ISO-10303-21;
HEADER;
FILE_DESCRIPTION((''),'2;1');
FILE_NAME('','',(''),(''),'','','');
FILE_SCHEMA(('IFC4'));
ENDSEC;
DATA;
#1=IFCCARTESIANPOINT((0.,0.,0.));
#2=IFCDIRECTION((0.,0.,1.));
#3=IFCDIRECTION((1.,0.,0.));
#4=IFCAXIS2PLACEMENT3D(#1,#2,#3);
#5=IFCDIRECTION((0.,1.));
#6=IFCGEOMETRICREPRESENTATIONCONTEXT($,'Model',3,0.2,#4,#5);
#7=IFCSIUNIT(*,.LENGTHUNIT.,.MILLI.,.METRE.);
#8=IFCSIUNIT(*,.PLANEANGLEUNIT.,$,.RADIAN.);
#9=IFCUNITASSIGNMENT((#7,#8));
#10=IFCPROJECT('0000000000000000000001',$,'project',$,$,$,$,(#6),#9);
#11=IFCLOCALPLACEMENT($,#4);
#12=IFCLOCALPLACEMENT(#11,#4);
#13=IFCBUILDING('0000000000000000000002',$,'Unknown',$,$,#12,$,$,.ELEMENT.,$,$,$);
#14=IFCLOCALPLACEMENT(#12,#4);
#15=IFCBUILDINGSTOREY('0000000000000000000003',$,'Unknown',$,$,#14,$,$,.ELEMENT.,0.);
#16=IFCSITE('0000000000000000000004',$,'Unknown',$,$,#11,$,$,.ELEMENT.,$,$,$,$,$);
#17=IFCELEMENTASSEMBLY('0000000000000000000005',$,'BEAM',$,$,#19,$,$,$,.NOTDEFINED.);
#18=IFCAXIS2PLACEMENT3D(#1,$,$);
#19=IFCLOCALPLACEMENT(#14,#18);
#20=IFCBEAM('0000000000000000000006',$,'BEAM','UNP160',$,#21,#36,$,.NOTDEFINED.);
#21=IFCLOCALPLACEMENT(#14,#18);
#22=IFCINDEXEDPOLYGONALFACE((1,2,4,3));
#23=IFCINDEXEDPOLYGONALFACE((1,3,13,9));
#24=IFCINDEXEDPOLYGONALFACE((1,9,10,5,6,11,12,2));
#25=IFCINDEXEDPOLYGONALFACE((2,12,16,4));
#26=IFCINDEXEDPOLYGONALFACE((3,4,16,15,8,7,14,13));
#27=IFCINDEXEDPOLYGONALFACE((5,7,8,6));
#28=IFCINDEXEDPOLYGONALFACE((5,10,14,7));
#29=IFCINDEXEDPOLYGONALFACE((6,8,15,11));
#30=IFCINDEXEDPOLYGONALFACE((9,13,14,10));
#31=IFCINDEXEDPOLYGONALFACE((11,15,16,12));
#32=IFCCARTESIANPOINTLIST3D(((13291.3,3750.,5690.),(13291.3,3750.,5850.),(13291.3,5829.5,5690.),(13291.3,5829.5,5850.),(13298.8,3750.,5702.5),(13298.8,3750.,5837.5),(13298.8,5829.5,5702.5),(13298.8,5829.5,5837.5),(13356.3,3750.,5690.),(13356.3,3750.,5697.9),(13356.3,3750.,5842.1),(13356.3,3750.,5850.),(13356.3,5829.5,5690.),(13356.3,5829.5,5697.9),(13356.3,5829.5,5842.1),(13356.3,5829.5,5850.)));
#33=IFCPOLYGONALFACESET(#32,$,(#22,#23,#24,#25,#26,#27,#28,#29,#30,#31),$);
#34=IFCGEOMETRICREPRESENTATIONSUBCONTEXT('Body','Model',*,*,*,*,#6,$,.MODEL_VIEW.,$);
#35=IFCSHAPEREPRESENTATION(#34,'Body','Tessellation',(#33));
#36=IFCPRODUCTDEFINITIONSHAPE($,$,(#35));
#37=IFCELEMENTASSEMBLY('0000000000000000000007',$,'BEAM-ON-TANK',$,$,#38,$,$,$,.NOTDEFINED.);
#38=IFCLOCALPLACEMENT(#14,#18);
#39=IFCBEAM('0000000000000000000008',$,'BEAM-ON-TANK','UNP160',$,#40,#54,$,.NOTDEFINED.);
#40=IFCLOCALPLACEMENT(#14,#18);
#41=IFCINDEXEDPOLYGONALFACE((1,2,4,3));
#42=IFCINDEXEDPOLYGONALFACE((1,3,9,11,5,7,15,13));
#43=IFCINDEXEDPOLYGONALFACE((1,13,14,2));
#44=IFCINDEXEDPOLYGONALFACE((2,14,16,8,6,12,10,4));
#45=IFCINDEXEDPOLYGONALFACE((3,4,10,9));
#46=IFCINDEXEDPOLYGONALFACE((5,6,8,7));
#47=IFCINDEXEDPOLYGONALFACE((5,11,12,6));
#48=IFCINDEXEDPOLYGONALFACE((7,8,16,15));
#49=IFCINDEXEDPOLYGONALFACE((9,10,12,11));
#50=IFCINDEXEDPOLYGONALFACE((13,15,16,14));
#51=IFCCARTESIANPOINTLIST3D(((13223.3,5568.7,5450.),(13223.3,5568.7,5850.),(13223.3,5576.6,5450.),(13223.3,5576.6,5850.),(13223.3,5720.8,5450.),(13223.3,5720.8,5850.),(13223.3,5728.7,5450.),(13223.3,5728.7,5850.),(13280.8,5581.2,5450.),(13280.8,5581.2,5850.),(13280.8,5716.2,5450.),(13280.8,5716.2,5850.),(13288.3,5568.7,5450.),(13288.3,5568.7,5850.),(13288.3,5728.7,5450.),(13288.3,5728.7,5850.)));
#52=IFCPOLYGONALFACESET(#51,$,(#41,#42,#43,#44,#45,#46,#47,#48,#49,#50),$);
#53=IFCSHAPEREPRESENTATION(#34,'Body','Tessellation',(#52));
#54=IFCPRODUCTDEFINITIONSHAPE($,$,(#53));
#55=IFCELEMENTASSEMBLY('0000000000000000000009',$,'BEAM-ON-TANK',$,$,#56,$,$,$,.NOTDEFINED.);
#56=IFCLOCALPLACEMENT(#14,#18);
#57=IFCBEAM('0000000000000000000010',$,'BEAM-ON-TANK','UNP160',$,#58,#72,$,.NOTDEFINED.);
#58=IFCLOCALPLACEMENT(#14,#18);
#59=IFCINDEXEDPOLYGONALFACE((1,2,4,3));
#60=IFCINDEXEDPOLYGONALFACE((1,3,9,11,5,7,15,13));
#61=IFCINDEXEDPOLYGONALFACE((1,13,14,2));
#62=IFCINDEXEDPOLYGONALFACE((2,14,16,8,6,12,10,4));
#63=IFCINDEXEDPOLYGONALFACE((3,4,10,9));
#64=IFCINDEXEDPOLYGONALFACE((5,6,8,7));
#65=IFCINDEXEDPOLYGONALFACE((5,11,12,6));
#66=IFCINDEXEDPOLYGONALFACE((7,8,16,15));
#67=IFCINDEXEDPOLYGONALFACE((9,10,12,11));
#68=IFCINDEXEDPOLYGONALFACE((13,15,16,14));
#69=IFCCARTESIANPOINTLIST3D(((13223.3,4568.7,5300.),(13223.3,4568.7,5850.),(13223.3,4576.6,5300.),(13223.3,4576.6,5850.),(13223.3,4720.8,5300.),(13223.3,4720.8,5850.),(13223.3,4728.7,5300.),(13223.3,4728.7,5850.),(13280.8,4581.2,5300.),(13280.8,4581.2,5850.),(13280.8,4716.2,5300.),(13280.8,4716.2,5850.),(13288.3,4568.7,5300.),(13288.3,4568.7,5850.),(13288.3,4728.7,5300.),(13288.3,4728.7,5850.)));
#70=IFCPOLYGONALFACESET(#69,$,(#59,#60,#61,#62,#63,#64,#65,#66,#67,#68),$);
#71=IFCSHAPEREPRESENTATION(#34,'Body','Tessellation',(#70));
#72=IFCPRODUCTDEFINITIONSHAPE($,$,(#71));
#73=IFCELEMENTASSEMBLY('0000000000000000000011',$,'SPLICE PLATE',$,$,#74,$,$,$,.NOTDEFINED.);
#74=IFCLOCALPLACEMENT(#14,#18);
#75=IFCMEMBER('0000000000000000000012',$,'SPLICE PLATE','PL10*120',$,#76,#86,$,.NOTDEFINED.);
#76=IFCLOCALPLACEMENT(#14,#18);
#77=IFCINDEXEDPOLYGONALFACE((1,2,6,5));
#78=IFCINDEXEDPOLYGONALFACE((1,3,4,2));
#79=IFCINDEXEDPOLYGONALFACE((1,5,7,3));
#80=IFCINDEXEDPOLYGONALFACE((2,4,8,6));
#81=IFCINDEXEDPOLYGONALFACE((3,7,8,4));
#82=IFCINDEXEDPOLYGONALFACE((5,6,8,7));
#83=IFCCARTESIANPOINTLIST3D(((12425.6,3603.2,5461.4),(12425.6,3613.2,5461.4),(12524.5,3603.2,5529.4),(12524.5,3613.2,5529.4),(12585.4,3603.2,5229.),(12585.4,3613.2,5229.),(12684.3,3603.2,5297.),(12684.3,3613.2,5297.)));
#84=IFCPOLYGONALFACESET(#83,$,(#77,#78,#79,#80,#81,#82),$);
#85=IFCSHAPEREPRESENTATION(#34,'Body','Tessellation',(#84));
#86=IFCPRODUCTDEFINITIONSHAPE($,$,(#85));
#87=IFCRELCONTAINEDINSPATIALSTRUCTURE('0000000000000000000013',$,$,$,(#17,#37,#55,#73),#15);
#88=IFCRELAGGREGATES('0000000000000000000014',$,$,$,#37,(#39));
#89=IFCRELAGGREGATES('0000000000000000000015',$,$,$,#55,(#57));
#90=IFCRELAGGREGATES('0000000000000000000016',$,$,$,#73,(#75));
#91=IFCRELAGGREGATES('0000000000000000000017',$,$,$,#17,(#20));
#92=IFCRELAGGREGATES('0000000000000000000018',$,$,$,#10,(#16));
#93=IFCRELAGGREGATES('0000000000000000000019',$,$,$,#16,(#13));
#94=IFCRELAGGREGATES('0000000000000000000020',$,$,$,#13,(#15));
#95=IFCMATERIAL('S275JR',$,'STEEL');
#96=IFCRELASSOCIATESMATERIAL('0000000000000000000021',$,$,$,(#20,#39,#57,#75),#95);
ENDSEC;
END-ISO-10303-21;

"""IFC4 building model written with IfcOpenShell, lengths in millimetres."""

from ifc_helpers import new_model, si_unit, direction, frame, origin_with_axes, place, context, subcontext, project, spatial, line, indexed_curve, outline, extrude, material, element, aggregate, save


model = new_model("IFC4")

# Units and contexts
model_context = context("Model", 3, precision=0.2, world=origin_with_axes(), true_north=direction((0.0, 1.0)))
body_context = subcontext(model_context, "Body", "Model", "MODEL_VIEW")
ifc_project = project(units=[si_unit("LENGTHUNIT", "METRE", prefix="MILLI"), si_unit("PLANEANGLEUNIT", "RADIAN")], contexts=[model_context])

# Site, building, storey
site_placement = place(None, origin_with_axes())
site = spatial("IfcSite", under=ifc_project, at=site_placement, Name="Unknown", CompositionType="ELEMENT")
building_placement = place(site_placement, origin_with_axes())
building = spatial("IfcBuilding", under=site, at=building_placement, Name="Unknown", CompositionType="ELEMENT")
storey_placement = place(building_placement, origin_with_axes())
storey = spatial("IfcBuildingStorey", under=building, at=storey_placement, Name="Unknown", CompositionType="ELEMENT", Elevation=0.0)

# Shared definitions
ifc_material_1 = material(Name="S275JR", Category="STEEL")

# Element assemblies, beams
assembly_1_placement = place(storey_placement, frame((13356.3, 5797.0, 5770.0), z_axis=(0.0, 1.0, 0.0), x_axis=(-1.0, 0.0, 0.0)))
assembly_1 = element("IfcElementAssembly", 1, at=assembly_1_placement, inside=storey, Name="BEAM", PredefinedType="NOTDEFINED")
beam_1_placement = place(assembly_1_placement, frame((32.5, 0.0, 32.5), z_axis=(-1.0, 0.0, 0.0), x_axis=(0.0, -0.000002, -1.0)))
beam_1 = element("IfcBeam", 2, at=beam_1_placement, material=ifc_material_1, Name="BEAM", Description="UNP160", PredefinedType="NOTDEFINED", context=body_context, shape_type="SolidModel", body=[
    extrude(outline(indexed_curve([(-32.5, -80.0), (32.5, -80.0), (32.5, -72.1), (-25.0, -67.5), (-25.0, 67.5), (32.5, 72.1), (32.5, 80.0), (-32.5, 80.0)], segments=[line(1, 2, 3, 4, 5, 6, 7, 8, 1)])), frame((0.0, 0.0, 0.0), z_axis=(-1.0, 0.0, 0.0), x_axis=(0.0, 0.0, 1.0)), (0.0, -0.000002, -1.0), 2079.5),
])
assembly_2_placement = place(storey_placement, frame((13255.8, 5648.7, 5850.0), z_axis=(-1.0, 0.0, 0.0), x_axis=(0.0, -0.000002, -1.0)))
assembly_2 = element("IfcElementAssembly", 3, at=assembly_2_placement, inside=storey, Name="BEAM-ON-TANK", PredefinedType="NOTDEFINED")
beam_2_placement = place(assembly_2_placement, origin_with_axes())
beam_2 = element("IfcBeam", 4, at=beam_2_placement, material=ifc_material_1, Name="BEAM-ON-TANK", Description="UNP160", PredefinedType="NOTDEFINED", context=body_context, shape_type="SolidModel", body=[
    extrude(outline(indexed_curve([(-32.5, -80.0), (32.5, -80.0), (32.5, -72.1), (-25.0, -67.5), (-25.0, 67.5), (32.5, 72.1), (32.5, 80.0), (-32.5, 80.0)], segments=[line(1, 2, 3, 4, 5, 6, 7, 8, 1)])), frame((0.0, 0.0, 0.0), z_axis=(-1.0, 0.0, 0.0), x_axis=(0.0, 0.0, 1.0)), (0.0, -0.000002, -1.0), 400.0),
])
aggregate(assembly_2, [beam_2])
assembly_3_placement = place(storey_placement, frame((13255.8, 4648.7, 5850.0), z_axis=(-1.0, 0.0, 0.0), x_axis=(0.0, -0.000002, -1.0)))
assembly_3 = element("IfcElementAssembly", 5, at=assembly_3_placement, inside=storey, Name="BEAM-ON-TANK", PredefinedType="NOTDEFINED")
beam_3_placement = place(assembly_3_placement, origin_with_axes())
beam_3 = element("IfcBeam", 6, at=beam_3_placement, material=ifc_material_1, Name="BEAM-ON-TANK", Description="UNP160", PredefinedType="NOTDEFINED", context=body_context, shape_type="SolidModel", body=[
    extrude(outline(indexed_curve([(-32.5, -80.0), (32.5, -80.0), (32.5, -72.1), (-25.0, -67.5), (-25.0, 67.5), (32.5, 72.1), (32.5, 80.0), (-32.5, 80.0)], segments=[line(1, 2, 3, 4, 5, 6, 7, 8, 1)])), frame((0.0, 0.0, 0.0), z_axis=(-1.0, 0.0, 0.0), x_axis=(0.0, 0.0, 1.0)), (0.0, -0.000002, -1.0), 550.0),
])
aggregate(assembly_3, [beam_3])

# Element assembly, member
assembly_4_placement = place(storey_placement, frame((12475.1, 3608.2, 5495.4), z_axis=(-0.000002, -1.0, 0.0), x_axis=(0.566581, 0.0, -0.824006)))
assembly_4 = element("IfcElementAssembly", 7, at=assembly_4_placement, inside=storey, Name="SPLICE PLATE", PredefinedType="NOTDEFINED")
member_placement = place(assembly_4_placement, origin_with_axes())
member = element("IfcMember", 8, at=member_placement, material=ifc_material_1, Name="SPLICE PLATE", Description="PL10*120", PredefinedType="NOTDEFINED", context=body_context, shape_type="SolidModel", body=[
    extrude(outline(indexed_curve([(-5.0, -60.0), (5.0, -60.0), (5.0, 60.0), (-5.0, 60.0)], segments=[line(1, 2, 3, 4, 1)])), frame((0.0, 0.0, 0.0), z_axis=(-1.0, 0.0, 0.0), x_axis=(0.0, 0.0, 1.0)), (0.0, -0.000002, -1.0), 282.0),
])
aggregate(assembly_4, [member])

aggregate(assembly_1, [beam_1])

save(model, "model.ifc")
